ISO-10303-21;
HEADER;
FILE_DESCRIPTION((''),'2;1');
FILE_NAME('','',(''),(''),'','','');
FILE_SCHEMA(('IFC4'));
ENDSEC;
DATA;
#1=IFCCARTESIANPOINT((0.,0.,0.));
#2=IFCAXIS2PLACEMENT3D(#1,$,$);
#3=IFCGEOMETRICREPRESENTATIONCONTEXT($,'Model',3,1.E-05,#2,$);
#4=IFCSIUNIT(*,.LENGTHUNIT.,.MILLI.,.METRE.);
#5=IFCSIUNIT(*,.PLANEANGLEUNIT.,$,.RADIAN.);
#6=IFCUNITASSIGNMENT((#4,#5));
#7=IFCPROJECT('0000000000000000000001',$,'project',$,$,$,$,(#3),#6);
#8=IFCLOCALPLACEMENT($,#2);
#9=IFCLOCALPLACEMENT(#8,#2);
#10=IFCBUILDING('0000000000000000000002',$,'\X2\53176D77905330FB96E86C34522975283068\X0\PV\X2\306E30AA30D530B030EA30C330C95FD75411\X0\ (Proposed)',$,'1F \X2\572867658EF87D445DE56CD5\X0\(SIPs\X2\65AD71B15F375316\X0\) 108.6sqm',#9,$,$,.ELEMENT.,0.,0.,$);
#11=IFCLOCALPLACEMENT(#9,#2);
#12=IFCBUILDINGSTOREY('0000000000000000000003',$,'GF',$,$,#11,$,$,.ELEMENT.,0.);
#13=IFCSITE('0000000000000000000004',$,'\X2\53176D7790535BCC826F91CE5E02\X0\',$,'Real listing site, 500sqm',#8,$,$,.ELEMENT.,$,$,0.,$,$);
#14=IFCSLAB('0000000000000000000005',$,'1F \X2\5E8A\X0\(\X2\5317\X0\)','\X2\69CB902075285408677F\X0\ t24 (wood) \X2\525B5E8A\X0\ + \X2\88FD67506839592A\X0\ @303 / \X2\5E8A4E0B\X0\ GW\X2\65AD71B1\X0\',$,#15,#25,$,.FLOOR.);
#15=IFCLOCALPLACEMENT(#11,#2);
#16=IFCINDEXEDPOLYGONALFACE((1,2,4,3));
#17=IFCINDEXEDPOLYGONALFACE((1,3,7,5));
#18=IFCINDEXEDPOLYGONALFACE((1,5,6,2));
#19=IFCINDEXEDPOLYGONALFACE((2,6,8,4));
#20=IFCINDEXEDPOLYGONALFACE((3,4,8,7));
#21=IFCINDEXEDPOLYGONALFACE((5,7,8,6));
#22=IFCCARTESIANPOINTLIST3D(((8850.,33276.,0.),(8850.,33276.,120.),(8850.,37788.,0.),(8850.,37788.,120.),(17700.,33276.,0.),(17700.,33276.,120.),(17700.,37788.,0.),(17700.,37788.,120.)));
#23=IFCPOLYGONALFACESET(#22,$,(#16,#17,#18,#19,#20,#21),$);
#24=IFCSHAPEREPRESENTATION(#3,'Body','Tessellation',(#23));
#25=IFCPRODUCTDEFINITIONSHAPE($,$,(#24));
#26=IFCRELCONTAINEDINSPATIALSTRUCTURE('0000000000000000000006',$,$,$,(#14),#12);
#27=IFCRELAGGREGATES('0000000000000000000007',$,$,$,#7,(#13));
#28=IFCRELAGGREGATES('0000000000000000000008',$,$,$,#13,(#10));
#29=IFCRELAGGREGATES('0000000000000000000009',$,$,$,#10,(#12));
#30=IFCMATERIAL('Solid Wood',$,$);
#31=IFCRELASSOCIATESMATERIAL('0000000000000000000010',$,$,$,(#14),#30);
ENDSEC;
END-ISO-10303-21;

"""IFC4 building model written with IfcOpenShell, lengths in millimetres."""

from ifc_helpers import new_model, si_unit, frame, frame_2d, origin, place, context, project, spatial, rectangle, extrude, material, element, save


model = new_model("IFC4")

# Units and contexts
model_context = context("Model", 3, precision=1e-05, world=origin())
ifc_project = project(units=[si_unit("LENGTHUNIT", "METRE", prefix="MILLI"), si_unit("PLANEANGLEUNIT", "RADIAN")], contexts=[model_context])

# Site, building, storey
site_placement = place(None, origin())
site = spatial("IfcSite", under=ifc_project, at=site_placement, Name="北海道富良野市", ObjectType="Real listing site, 500sqm", CompositionType="ELEMENT", RefElevation=0.0)
building_placement = place(site_placement, origin())
building = spatial("IfcBuilding", under=site, at=building_placement, Name="北海道・雨水利用とPVのオフグリッド志向 (Proposed)", ObjectType="1F 在来軸組工法(SIPs断熱強化) 108.6sqm", CompositionType="ELEMENT", ElevationOfRefHeight=0.0, ElevationOfTerrain=0.0)
storey_placement = place(building_placement, origin())
storey = spatial("IfcBuildingStorey", under=building, at=storey_placement, Name="GF", CompositionType="ELEMENT", Elevation=0.0)

# Shared definitions
ifc_material_1 = material(Name="Solid Wood")

# Slab
slab_placement = place(storey_placement, frame((4425.0, 16638.0, 0.0)))
element("IfcSlab", 1, at=slab_placement, inside=storey, material=ifc_material_1, Name="1F 床(北)", Description="構造用合板 t24 (wood) 剛床 + 製材根太 @303 / 床下 GW断熱", PredefinedType="FLOOR", context=model_context, shape_type="SweptSolid", body=[
    extrude(rectangle(XDim=8850.0, YDim=4512.0, at=frame_2d((4425.0, 2256.0))), frame((4425.0, 16638.0, 0.0)), (0.0, 0.0, 1.0), 120.0),
])

save(model, "model.ifc")
